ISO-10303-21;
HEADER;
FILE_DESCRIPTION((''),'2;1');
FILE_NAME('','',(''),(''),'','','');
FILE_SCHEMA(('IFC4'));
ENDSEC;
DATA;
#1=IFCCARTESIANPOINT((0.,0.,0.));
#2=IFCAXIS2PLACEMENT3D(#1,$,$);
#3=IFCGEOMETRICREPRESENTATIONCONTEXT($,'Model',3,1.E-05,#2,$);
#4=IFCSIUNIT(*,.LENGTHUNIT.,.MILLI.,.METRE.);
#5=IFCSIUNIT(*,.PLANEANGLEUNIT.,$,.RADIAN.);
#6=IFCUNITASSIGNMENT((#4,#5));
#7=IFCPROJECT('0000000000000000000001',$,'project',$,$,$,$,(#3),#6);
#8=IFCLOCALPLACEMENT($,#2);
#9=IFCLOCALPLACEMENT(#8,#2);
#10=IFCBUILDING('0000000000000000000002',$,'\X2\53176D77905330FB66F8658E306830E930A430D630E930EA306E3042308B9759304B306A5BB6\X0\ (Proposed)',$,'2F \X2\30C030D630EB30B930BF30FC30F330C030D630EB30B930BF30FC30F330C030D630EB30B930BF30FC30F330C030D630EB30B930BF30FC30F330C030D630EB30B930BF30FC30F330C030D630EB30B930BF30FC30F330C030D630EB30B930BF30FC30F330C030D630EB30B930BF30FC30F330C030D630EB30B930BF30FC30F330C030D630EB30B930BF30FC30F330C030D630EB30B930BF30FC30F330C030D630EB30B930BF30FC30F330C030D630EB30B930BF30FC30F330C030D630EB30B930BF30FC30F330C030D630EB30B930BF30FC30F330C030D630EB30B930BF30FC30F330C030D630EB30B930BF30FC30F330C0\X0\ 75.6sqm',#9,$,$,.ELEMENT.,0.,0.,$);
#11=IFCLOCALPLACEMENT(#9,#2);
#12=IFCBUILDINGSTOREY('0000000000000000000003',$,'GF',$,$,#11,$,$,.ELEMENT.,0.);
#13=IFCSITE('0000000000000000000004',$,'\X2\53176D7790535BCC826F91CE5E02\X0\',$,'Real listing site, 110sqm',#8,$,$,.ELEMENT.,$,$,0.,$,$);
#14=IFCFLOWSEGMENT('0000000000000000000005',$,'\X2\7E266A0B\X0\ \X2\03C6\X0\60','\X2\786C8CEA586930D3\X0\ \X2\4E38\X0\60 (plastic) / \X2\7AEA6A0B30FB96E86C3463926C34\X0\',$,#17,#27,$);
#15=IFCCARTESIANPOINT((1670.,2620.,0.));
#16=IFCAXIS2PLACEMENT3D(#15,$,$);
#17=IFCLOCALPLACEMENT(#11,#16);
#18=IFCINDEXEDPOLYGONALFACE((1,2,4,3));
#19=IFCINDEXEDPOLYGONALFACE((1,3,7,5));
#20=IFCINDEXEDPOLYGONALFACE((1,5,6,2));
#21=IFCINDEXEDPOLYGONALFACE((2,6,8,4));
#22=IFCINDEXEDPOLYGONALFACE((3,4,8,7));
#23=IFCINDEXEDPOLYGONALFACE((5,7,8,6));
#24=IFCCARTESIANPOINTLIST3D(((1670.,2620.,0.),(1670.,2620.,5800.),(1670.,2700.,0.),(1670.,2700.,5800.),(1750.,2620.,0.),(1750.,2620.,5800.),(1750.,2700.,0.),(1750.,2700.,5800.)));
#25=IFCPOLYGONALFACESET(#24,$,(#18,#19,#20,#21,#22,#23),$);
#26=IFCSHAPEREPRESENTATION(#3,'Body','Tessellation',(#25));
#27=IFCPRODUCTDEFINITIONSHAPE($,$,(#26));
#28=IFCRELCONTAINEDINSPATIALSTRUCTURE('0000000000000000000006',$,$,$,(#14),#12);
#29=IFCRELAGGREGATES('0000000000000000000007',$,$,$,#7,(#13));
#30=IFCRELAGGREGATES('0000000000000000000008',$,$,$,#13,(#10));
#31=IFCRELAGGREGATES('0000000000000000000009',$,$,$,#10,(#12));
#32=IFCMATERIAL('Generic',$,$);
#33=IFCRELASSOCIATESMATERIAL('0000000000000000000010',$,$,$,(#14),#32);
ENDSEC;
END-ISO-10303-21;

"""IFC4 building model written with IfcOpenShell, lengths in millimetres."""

from ifc_helpers import new_model, si_unit, frame, frame_2d, origin, place, context, project, spatial, rectangle, extrude, material, element, save


model = new_model("IFC4")

# Units and contexts
model_context = context("Model", 3, precision=1e-05, world=origin())
ifc_project = project(units=[si_unit("LENGTHUNIT", "METRE", prefix="MILLI"), si_unit("PLANEANGLEUNIT", "RADIAN")], contexts=[model_context])

# Site, building, storey
site_placement = place(None, origin())
site = spatial("IfcSite", under=ifc_project, at=site_placement, Name="北海道富良野市", ObjectType="Real listing site, 110sqm", CompositionType="ELEMENT", RefElevation=0.0)
building_placement = place(site_placement, origin())
building = spatial("IfcBuilding", under=site, at=building_placement, Name="北海道・書斎とライブラリのある静かな家 (Proposed)", ObjectType="2F ダブルスターンダブルスターンダブルスターンダブルスターンダブルスターンダブルスターンダブルスターンダブルスターンダブルスターンダブルスターンダブルスターンダブルスターンダブルスターンダブルスターンダブルスターンダブルスターンダブルスターンダ 75.6sqm", CompositionType="ELEMENT", ElevationOfRefHeight=0.0, ElevationOfTerrain=0.0)
storey_placement = place(building_placement, origin())
storey = spatial("IfcBuildingStorey", under=building, at=storey_placement, Name="GF", CompositionType="ELEMENT", Elevation=0.0)

# Flow segment
ifc_material_1 = material(Name="Generic")
flow_segment_1_placement = place(storey_placement, frame((1670.0, 2620.0, 0.0)))
element("IfcFlowSegment", 1, at=flow_segment_1_placement, inside=storey, material=ifc_material_1, Name="縦樋 φ60", Description="硬質塩ビ 丸60 (plastic) / 竪樋・雨水排水", context=model_context, shape_type="SweptSolid", body=[
    extrude(rectangle(XDim=80.0, YDim=80.0, at=frame_2d((40.0, 40.0))), frame((1670.0, 2620.0, 0.0)), (0.0, 0.0, 1.0), 5800.0),
])

save(model, "model.ifc")
